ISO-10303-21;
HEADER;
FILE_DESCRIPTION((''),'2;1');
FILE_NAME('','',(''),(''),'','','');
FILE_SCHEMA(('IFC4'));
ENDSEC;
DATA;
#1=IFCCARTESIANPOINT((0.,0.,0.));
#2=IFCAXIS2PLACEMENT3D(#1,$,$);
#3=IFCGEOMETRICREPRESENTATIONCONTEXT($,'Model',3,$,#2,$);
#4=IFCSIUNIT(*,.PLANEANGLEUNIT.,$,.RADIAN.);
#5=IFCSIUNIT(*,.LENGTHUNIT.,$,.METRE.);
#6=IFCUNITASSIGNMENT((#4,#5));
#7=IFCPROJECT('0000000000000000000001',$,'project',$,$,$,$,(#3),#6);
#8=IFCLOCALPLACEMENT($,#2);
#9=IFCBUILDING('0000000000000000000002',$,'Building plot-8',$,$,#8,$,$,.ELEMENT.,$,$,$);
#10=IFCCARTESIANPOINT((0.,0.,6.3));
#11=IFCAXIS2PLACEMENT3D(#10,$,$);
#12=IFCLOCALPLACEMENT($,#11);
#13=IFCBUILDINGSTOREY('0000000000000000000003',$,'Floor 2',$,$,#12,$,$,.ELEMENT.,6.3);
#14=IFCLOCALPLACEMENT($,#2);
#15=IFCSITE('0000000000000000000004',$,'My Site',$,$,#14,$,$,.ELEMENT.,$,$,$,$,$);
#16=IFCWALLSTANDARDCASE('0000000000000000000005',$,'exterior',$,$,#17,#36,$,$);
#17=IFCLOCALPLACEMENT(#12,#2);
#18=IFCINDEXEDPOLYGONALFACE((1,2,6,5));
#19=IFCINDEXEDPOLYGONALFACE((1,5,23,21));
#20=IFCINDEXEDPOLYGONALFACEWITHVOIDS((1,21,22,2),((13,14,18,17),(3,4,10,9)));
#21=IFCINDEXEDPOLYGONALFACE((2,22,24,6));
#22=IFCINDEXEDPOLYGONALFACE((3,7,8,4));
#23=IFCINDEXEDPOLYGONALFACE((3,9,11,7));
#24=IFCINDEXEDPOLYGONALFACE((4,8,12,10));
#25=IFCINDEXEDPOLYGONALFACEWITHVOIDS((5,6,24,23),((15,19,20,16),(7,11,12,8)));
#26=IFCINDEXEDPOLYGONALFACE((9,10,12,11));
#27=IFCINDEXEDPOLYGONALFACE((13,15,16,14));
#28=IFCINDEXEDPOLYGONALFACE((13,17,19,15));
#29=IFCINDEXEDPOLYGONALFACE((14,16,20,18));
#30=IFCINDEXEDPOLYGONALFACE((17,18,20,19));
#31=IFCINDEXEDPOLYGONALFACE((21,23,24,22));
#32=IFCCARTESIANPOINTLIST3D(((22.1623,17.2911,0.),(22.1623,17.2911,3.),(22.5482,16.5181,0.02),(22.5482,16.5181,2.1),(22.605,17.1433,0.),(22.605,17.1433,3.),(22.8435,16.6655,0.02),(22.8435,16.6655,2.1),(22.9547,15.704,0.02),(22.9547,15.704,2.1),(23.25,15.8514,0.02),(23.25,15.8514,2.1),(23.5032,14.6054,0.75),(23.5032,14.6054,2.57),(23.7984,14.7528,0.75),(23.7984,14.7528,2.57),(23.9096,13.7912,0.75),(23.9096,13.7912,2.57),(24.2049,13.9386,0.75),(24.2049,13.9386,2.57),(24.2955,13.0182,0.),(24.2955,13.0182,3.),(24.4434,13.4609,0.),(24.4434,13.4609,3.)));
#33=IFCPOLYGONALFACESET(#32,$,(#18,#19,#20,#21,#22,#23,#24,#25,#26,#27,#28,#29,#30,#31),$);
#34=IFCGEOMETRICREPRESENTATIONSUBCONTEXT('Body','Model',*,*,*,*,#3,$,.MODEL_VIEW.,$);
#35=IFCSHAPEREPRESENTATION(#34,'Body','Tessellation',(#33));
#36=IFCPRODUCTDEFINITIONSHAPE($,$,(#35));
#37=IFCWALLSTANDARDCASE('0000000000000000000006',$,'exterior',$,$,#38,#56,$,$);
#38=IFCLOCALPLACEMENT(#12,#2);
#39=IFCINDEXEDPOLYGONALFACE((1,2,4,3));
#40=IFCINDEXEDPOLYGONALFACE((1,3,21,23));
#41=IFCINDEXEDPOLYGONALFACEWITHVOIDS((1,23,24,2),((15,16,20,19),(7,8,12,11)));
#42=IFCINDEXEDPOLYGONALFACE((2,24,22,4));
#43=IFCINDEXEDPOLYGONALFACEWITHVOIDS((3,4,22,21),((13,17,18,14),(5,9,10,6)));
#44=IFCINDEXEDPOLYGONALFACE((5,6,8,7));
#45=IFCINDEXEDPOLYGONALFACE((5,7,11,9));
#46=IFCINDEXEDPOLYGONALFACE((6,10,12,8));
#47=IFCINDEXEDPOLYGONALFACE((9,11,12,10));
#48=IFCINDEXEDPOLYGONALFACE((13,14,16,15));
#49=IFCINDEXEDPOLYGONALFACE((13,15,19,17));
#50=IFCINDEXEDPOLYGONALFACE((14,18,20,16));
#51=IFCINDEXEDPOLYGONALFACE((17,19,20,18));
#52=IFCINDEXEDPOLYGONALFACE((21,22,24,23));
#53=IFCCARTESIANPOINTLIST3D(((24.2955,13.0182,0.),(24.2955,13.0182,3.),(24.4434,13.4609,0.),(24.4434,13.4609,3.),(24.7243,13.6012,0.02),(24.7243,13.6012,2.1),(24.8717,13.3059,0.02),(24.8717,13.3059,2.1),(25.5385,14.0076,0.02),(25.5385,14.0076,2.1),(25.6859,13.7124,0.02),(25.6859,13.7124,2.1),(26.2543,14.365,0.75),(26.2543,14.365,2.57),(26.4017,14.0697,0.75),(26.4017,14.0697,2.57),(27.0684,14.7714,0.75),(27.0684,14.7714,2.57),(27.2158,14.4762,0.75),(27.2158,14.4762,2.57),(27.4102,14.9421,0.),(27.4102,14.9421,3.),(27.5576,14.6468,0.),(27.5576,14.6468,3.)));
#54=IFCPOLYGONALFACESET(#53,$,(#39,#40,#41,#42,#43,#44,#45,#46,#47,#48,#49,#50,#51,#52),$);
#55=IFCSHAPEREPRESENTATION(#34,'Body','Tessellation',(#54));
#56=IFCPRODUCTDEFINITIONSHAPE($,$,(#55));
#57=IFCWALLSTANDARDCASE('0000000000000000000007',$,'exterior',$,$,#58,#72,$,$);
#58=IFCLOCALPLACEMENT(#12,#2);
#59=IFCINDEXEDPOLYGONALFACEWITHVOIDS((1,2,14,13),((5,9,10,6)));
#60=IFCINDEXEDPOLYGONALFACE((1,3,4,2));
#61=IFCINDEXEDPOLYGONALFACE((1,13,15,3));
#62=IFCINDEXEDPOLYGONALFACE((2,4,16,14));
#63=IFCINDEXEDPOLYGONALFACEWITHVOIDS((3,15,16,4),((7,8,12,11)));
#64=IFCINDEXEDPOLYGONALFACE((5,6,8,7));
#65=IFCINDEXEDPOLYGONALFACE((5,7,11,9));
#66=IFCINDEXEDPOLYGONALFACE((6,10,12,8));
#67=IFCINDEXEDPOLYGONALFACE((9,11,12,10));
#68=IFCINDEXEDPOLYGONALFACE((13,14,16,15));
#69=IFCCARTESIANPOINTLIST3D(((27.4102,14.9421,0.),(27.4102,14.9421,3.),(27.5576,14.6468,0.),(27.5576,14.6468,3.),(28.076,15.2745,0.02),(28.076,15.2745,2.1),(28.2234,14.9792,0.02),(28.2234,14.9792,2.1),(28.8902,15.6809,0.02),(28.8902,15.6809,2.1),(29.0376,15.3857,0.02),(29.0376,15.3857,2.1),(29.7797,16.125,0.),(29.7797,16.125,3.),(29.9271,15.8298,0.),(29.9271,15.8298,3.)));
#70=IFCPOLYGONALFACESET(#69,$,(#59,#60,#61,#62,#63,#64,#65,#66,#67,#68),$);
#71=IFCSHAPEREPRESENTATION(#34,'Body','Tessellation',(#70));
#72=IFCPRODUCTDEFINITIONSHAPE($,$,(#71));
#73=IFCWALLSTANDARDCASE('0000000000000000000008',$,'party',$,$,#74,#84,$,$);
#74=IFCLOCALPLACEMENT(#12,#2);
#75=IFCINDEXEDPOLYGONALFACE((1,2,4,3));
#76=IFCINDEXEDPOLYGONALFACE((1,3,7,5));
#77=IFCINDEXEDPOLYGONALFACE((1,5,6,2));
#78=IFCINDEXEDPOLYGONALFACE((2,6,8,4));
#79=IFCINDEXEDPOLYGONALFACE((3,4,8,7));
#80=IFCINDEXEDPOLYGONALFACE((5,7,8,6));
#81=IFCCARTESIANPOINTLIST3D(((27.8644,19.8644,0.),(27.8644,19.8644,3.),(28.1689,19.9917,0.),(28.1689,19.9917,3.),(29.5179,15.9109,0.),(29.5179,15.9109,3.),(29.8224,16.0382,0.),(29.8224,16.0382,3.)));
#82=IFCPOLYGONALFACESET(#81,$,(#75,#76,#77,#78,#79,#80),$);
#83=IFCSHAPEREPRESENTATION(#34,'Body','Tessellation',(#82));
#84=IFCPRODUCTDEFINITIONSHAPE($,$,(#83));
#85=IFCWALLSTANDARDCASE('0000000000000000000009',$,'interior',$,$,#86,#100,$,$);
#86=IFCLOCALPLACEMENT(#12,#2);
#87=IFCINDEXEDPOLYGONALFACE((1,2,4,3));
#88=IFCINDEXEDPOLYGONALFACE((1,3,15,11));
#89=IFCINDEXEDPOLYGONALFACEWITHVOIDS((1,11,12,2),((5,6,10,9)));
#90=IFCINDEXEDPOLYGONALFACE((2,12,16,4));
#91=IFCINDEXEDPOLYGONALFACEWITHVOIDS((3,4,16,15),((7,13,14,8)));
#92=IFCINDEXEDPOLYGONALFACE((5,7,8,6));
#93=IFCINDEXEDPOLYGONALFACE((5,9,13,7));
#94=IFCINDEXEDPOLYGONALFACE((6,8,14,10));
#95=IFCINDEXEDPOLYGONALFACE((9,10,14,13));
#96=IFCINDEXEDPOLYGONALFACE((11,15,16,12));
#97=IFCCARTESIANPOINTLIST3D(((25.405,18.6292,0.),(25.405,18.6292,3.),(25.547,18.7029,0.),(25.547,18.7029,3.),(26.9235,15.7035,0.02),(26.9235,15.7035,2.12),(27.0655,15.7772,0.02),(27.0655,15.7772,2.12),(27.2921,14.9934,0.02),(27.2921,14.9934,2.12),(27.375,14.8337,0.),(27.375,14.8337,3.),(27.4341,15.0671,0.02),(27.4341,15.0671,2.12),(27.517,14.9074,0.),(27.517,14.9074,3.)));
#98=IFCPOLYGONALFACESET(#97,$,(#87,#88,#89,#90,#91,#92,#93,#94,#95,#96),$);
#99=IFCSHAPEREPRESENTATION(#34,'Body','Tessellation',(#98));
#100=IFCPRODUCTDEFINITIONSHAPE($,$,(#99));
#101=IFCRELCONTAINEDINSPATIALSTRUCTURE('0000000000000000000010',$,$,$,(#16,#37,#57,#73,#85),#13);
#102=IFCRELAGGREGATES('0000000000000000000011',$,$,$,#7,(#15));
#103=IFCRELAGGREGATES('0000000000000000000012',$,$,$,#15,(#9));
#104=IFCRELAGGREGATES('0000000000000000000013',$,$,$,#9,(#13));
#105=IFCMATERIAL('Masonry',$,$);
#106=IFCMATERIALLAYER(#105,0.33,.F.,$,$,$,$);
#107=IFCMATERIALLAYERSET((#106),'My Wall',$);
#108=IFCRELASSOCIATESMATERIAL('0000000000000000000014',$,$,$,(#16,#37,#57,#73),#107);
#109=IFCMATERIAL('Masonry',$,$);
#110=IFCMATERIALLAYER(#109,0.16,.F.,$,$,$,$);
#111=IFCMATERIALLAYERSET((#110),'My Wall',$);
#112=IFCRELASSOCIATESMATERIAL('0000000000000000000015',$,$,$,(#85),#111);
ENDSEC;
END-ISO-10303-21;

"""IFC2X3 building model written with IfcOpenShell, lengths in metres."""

from ifc_helpers import new_model, si_unit, frame, origin, place, context, subcontext, project, spatial, polyline, outline, extrude, material, layer, layer_set, layer_usage, element, save


model = new_model("IFC2X3")

# Units and contexts
model_context = context("Model", 3, world=origin())
body_context = subcontext(model_context, "Body", "Model", "MODEL_VIEW")
ifc_project = project(units=[si_unit("PLANEANGLEUNIT", "RADIAN"), si_unit("LENGTHUNIT", "METRE")], contexts=[model_context])

# Site, building, storey
site_placement = place(None, origin())
site = spatial("IfcSite", under=ifc_project, at=site_placement, Name="My Site", CompositionType="ELEMENT")
building_placement = place(None, origin())
building = spatial("IfcBuilding", under=site, at=building_placement, Name="Building plot-8", CompositionType="ELEMENT")
storey_placement = place(None, frame((0.0, 0.0, 6.3)))
storey = spatial("IfcBuildingStorey", under=building, at=storey_placement, Name="Floor 2", CompositionType="ELEMENT", Elevation=6.3)

# Shared definitions
ifc_material_1 = material(Name="Masonry")
ifc_layer_1 = layer(ifc_material_1, 0.33, ventilated=False)
ifc_layer_set_1 = layer_set([ifc_layer_1], Name="My Wall")
ifc_layer_usage_1 = layer_usage(ifc_layer_set_1, "AXIS2", "NEGATIVE", 0.08)

# Walls, openings
wall_1_placement = place(storey_placement, origin())
wall_1 = element("IfcWallStandardCase", 1, at=wall_1_placement, inside=storey, material=ifc_layer_usage_1, Name="exterior", context=body_context, shape_type="SweptSolid", body=[
    extrude(outline(polyline([(22.605, 17.1433), (22.1623, 17.2911), (24.2955, 13.0182), (24.4434, 13.4609), (22.605, 17.1433)])), origin(), (0.0, 0.0, 1.0), 3.0),
])
opening_1_placement = place(storey_placement, frame((0.0, 0.0, 0.02)))
element("IfcOpeningElement", 2, at=opening_1_placement, cuts=wall_1, ObjectType="Opening", context=body_context, shape_type="SweptSolid", body=[
    extrude(outline(polyline([(22.5482, 16.5181), (22.9547, 15.704), (23.25, 15.8514), (22.8435, 16.6655), (22.5482, 16.5181)])), origin(), (0.0, 0.0, 1.0), 2.08),
])
opening_2_placement = place(storey_placement, frame((0.0, 0.0, 0.75)))
element("IfcOpeningElement", 3, at=opening_2_placement, cuts=wall_1, ObjectType="Opening", context=body_context, shape_type="SweptSolid", body=[
    extrude(outline(polyline([(23.5032, 14.6054), (23.9096, 13.7912), (24.2049, 13.9386), (23.7984, 14.7528), (23.5032, 14.6054)])), origin(), (0.0, 0.0, 1.0), 1.82),
])
wall_2_placement = place(storey_placement, origin())
wall_2 = element("IfcWallStandardCase", 4, at=wall_2_placement, inside=storey, material=ifc_layer_usage_1, Name="exterior", context=body_context, shape_type="SweptSolid", body=[
    extrude(outline(polyline([(24.4434, 13.4609), (24.2955, 13.0182), (27.5576, 14.6468), (27.4102, 14.9421), (24.4434, 13.4609)])), origin(), (0.0, 0.0, 1.0), 3.0),
])
opening_3_placement = place(storey_placement, frame((0.0, 0.0, 0.02)))
element("IfcOpeningElement", 5, at=opening_3_placement, cuts=wall_2, ObjectType="Opening", context=body_context, shape_type="SweptSolid", body=[
    extrude(outline(polyline([(24.8717, 13.3059), (25.6859, 13.7124), (25.5385, 14.0076), (24.7243, 13.6012), (24.8717, 13.3059)])), origin(), (0.0, 0.0, 1.0), 2.08),
])
opening_4_placement = place(storey_placement, frame((0.0, 0.0, 0.75)))
element("IfcOpeningElement", 6, at=opening_4_placement, cuts=wall_2, ObjectType="Opening", context=body_context, shape_type="SweptSolid", body=[
    extrude(outline(polyline([(26.4017, 14.0697), (27.2158, 14.4762), (27.0684, 14.7714), (26.2543, 14.365), (26.4017, 14.0697)])), origin(), (0.0, 0.0, 1.0), 1.82),
])

# Wall, opening
wall_3_placement = place(storey_placement, origin())
wall_3 = element("IfcWallStandardCase", 7, at=wall_3_placement, inside=storey, material=ifc_layer_usage_1, Name="exterior", context=body_context, shape_type="SweptSolid", body=[
    extrude(outline(polyline([(27.4102, 14.9421), (27.5576, 14.6468), (29.9271, 15.8298), (29.7797, 16.125), (27.4102, 14.9421)])), origin(), (0.0, 0.0, 1.0), 3.0),
])
opening_5_placement = place(storey_placement, frame((0.0, 0.0, 0.02)))
element("IfcOpeningElement", 8, at=opening_5_placement, cuts=wall_3, ObjectType="Opening", context=body_context, shape_type="SweptSolid", body=[
    extrude(outline(polyline([(28.2234, 14.9792), (29.0376, 15.3857), (28.8902, 15.6809), (28.076, 15.2745), (28.2234, 14.9792)])), origin(), (0.0, 0.0, 1.0), 2.08),
])

# Wall
wall_4_placement = place(storey_placement, origin())
element("IfcWallStandardCase", 9, at=wall_4_placement, inside=storey, material=ifc_layer_usage_1, Name="party", context=body_context, shape_type="SweptSolid", body=[
    extrude(outline(polyline([(29.5179, 15.9109), (29.8224, 16.0382), (28.1689, 19.9917), (27.8644, 19.8644), (29.5179, 15.9109)])), origin(), (0.0, 0.0, 1.0), 3.0),
])

# Wall, opening
ifc_material_2 = material(Name="Masonry")
ifc_layer_2 = layer(ifc_material_2, 0.16, ventilated=False)
ifc_layer_set_2 = layer_set([ifc_layer_2], Name="My Wall")
ifc_layer_usage_2 = layer_usage(ifc_layer_set_2, "AXIS2", "NEGATIVE", 0.08)
wall_5_placement = place(storey_placement, origin())
wall_5 = element("IfcWallStandardCase", 10, at=wall_5_placement, inside=storey, material=ifc_layer_usage_2, Name="interior", context=body_context, shape_type="SweptSolid", body=[
    extrude(outline(polyline([(25.547, 18.7029), (25.405, 18.6292), (27.375, 14.8337), (27.517, 14.9074), (25.547, 18.7029)])), origin(), (0.0, 0.0, 1.0), 3.0),
])
opening_6_placement = place(storey_placement, frame((0.0, 0.0, 0.02)))
element("IfcOpeningElement", 11, at=opening_6_placement, cuts=wall_5, ObjectType="Opening", context=body_context, shape_type="SweptSolid", body=[
    extrude(outline(polyline([(26.9235, 15.7035), (27.2921, 14.9934), (27.4341, 15.0671), (27.0655, 15.7772), (26.9235, 15.7035)])), origin(), (0.0, 0.0, 1.0), 2.1),
])

save(model, "model.ifc")
